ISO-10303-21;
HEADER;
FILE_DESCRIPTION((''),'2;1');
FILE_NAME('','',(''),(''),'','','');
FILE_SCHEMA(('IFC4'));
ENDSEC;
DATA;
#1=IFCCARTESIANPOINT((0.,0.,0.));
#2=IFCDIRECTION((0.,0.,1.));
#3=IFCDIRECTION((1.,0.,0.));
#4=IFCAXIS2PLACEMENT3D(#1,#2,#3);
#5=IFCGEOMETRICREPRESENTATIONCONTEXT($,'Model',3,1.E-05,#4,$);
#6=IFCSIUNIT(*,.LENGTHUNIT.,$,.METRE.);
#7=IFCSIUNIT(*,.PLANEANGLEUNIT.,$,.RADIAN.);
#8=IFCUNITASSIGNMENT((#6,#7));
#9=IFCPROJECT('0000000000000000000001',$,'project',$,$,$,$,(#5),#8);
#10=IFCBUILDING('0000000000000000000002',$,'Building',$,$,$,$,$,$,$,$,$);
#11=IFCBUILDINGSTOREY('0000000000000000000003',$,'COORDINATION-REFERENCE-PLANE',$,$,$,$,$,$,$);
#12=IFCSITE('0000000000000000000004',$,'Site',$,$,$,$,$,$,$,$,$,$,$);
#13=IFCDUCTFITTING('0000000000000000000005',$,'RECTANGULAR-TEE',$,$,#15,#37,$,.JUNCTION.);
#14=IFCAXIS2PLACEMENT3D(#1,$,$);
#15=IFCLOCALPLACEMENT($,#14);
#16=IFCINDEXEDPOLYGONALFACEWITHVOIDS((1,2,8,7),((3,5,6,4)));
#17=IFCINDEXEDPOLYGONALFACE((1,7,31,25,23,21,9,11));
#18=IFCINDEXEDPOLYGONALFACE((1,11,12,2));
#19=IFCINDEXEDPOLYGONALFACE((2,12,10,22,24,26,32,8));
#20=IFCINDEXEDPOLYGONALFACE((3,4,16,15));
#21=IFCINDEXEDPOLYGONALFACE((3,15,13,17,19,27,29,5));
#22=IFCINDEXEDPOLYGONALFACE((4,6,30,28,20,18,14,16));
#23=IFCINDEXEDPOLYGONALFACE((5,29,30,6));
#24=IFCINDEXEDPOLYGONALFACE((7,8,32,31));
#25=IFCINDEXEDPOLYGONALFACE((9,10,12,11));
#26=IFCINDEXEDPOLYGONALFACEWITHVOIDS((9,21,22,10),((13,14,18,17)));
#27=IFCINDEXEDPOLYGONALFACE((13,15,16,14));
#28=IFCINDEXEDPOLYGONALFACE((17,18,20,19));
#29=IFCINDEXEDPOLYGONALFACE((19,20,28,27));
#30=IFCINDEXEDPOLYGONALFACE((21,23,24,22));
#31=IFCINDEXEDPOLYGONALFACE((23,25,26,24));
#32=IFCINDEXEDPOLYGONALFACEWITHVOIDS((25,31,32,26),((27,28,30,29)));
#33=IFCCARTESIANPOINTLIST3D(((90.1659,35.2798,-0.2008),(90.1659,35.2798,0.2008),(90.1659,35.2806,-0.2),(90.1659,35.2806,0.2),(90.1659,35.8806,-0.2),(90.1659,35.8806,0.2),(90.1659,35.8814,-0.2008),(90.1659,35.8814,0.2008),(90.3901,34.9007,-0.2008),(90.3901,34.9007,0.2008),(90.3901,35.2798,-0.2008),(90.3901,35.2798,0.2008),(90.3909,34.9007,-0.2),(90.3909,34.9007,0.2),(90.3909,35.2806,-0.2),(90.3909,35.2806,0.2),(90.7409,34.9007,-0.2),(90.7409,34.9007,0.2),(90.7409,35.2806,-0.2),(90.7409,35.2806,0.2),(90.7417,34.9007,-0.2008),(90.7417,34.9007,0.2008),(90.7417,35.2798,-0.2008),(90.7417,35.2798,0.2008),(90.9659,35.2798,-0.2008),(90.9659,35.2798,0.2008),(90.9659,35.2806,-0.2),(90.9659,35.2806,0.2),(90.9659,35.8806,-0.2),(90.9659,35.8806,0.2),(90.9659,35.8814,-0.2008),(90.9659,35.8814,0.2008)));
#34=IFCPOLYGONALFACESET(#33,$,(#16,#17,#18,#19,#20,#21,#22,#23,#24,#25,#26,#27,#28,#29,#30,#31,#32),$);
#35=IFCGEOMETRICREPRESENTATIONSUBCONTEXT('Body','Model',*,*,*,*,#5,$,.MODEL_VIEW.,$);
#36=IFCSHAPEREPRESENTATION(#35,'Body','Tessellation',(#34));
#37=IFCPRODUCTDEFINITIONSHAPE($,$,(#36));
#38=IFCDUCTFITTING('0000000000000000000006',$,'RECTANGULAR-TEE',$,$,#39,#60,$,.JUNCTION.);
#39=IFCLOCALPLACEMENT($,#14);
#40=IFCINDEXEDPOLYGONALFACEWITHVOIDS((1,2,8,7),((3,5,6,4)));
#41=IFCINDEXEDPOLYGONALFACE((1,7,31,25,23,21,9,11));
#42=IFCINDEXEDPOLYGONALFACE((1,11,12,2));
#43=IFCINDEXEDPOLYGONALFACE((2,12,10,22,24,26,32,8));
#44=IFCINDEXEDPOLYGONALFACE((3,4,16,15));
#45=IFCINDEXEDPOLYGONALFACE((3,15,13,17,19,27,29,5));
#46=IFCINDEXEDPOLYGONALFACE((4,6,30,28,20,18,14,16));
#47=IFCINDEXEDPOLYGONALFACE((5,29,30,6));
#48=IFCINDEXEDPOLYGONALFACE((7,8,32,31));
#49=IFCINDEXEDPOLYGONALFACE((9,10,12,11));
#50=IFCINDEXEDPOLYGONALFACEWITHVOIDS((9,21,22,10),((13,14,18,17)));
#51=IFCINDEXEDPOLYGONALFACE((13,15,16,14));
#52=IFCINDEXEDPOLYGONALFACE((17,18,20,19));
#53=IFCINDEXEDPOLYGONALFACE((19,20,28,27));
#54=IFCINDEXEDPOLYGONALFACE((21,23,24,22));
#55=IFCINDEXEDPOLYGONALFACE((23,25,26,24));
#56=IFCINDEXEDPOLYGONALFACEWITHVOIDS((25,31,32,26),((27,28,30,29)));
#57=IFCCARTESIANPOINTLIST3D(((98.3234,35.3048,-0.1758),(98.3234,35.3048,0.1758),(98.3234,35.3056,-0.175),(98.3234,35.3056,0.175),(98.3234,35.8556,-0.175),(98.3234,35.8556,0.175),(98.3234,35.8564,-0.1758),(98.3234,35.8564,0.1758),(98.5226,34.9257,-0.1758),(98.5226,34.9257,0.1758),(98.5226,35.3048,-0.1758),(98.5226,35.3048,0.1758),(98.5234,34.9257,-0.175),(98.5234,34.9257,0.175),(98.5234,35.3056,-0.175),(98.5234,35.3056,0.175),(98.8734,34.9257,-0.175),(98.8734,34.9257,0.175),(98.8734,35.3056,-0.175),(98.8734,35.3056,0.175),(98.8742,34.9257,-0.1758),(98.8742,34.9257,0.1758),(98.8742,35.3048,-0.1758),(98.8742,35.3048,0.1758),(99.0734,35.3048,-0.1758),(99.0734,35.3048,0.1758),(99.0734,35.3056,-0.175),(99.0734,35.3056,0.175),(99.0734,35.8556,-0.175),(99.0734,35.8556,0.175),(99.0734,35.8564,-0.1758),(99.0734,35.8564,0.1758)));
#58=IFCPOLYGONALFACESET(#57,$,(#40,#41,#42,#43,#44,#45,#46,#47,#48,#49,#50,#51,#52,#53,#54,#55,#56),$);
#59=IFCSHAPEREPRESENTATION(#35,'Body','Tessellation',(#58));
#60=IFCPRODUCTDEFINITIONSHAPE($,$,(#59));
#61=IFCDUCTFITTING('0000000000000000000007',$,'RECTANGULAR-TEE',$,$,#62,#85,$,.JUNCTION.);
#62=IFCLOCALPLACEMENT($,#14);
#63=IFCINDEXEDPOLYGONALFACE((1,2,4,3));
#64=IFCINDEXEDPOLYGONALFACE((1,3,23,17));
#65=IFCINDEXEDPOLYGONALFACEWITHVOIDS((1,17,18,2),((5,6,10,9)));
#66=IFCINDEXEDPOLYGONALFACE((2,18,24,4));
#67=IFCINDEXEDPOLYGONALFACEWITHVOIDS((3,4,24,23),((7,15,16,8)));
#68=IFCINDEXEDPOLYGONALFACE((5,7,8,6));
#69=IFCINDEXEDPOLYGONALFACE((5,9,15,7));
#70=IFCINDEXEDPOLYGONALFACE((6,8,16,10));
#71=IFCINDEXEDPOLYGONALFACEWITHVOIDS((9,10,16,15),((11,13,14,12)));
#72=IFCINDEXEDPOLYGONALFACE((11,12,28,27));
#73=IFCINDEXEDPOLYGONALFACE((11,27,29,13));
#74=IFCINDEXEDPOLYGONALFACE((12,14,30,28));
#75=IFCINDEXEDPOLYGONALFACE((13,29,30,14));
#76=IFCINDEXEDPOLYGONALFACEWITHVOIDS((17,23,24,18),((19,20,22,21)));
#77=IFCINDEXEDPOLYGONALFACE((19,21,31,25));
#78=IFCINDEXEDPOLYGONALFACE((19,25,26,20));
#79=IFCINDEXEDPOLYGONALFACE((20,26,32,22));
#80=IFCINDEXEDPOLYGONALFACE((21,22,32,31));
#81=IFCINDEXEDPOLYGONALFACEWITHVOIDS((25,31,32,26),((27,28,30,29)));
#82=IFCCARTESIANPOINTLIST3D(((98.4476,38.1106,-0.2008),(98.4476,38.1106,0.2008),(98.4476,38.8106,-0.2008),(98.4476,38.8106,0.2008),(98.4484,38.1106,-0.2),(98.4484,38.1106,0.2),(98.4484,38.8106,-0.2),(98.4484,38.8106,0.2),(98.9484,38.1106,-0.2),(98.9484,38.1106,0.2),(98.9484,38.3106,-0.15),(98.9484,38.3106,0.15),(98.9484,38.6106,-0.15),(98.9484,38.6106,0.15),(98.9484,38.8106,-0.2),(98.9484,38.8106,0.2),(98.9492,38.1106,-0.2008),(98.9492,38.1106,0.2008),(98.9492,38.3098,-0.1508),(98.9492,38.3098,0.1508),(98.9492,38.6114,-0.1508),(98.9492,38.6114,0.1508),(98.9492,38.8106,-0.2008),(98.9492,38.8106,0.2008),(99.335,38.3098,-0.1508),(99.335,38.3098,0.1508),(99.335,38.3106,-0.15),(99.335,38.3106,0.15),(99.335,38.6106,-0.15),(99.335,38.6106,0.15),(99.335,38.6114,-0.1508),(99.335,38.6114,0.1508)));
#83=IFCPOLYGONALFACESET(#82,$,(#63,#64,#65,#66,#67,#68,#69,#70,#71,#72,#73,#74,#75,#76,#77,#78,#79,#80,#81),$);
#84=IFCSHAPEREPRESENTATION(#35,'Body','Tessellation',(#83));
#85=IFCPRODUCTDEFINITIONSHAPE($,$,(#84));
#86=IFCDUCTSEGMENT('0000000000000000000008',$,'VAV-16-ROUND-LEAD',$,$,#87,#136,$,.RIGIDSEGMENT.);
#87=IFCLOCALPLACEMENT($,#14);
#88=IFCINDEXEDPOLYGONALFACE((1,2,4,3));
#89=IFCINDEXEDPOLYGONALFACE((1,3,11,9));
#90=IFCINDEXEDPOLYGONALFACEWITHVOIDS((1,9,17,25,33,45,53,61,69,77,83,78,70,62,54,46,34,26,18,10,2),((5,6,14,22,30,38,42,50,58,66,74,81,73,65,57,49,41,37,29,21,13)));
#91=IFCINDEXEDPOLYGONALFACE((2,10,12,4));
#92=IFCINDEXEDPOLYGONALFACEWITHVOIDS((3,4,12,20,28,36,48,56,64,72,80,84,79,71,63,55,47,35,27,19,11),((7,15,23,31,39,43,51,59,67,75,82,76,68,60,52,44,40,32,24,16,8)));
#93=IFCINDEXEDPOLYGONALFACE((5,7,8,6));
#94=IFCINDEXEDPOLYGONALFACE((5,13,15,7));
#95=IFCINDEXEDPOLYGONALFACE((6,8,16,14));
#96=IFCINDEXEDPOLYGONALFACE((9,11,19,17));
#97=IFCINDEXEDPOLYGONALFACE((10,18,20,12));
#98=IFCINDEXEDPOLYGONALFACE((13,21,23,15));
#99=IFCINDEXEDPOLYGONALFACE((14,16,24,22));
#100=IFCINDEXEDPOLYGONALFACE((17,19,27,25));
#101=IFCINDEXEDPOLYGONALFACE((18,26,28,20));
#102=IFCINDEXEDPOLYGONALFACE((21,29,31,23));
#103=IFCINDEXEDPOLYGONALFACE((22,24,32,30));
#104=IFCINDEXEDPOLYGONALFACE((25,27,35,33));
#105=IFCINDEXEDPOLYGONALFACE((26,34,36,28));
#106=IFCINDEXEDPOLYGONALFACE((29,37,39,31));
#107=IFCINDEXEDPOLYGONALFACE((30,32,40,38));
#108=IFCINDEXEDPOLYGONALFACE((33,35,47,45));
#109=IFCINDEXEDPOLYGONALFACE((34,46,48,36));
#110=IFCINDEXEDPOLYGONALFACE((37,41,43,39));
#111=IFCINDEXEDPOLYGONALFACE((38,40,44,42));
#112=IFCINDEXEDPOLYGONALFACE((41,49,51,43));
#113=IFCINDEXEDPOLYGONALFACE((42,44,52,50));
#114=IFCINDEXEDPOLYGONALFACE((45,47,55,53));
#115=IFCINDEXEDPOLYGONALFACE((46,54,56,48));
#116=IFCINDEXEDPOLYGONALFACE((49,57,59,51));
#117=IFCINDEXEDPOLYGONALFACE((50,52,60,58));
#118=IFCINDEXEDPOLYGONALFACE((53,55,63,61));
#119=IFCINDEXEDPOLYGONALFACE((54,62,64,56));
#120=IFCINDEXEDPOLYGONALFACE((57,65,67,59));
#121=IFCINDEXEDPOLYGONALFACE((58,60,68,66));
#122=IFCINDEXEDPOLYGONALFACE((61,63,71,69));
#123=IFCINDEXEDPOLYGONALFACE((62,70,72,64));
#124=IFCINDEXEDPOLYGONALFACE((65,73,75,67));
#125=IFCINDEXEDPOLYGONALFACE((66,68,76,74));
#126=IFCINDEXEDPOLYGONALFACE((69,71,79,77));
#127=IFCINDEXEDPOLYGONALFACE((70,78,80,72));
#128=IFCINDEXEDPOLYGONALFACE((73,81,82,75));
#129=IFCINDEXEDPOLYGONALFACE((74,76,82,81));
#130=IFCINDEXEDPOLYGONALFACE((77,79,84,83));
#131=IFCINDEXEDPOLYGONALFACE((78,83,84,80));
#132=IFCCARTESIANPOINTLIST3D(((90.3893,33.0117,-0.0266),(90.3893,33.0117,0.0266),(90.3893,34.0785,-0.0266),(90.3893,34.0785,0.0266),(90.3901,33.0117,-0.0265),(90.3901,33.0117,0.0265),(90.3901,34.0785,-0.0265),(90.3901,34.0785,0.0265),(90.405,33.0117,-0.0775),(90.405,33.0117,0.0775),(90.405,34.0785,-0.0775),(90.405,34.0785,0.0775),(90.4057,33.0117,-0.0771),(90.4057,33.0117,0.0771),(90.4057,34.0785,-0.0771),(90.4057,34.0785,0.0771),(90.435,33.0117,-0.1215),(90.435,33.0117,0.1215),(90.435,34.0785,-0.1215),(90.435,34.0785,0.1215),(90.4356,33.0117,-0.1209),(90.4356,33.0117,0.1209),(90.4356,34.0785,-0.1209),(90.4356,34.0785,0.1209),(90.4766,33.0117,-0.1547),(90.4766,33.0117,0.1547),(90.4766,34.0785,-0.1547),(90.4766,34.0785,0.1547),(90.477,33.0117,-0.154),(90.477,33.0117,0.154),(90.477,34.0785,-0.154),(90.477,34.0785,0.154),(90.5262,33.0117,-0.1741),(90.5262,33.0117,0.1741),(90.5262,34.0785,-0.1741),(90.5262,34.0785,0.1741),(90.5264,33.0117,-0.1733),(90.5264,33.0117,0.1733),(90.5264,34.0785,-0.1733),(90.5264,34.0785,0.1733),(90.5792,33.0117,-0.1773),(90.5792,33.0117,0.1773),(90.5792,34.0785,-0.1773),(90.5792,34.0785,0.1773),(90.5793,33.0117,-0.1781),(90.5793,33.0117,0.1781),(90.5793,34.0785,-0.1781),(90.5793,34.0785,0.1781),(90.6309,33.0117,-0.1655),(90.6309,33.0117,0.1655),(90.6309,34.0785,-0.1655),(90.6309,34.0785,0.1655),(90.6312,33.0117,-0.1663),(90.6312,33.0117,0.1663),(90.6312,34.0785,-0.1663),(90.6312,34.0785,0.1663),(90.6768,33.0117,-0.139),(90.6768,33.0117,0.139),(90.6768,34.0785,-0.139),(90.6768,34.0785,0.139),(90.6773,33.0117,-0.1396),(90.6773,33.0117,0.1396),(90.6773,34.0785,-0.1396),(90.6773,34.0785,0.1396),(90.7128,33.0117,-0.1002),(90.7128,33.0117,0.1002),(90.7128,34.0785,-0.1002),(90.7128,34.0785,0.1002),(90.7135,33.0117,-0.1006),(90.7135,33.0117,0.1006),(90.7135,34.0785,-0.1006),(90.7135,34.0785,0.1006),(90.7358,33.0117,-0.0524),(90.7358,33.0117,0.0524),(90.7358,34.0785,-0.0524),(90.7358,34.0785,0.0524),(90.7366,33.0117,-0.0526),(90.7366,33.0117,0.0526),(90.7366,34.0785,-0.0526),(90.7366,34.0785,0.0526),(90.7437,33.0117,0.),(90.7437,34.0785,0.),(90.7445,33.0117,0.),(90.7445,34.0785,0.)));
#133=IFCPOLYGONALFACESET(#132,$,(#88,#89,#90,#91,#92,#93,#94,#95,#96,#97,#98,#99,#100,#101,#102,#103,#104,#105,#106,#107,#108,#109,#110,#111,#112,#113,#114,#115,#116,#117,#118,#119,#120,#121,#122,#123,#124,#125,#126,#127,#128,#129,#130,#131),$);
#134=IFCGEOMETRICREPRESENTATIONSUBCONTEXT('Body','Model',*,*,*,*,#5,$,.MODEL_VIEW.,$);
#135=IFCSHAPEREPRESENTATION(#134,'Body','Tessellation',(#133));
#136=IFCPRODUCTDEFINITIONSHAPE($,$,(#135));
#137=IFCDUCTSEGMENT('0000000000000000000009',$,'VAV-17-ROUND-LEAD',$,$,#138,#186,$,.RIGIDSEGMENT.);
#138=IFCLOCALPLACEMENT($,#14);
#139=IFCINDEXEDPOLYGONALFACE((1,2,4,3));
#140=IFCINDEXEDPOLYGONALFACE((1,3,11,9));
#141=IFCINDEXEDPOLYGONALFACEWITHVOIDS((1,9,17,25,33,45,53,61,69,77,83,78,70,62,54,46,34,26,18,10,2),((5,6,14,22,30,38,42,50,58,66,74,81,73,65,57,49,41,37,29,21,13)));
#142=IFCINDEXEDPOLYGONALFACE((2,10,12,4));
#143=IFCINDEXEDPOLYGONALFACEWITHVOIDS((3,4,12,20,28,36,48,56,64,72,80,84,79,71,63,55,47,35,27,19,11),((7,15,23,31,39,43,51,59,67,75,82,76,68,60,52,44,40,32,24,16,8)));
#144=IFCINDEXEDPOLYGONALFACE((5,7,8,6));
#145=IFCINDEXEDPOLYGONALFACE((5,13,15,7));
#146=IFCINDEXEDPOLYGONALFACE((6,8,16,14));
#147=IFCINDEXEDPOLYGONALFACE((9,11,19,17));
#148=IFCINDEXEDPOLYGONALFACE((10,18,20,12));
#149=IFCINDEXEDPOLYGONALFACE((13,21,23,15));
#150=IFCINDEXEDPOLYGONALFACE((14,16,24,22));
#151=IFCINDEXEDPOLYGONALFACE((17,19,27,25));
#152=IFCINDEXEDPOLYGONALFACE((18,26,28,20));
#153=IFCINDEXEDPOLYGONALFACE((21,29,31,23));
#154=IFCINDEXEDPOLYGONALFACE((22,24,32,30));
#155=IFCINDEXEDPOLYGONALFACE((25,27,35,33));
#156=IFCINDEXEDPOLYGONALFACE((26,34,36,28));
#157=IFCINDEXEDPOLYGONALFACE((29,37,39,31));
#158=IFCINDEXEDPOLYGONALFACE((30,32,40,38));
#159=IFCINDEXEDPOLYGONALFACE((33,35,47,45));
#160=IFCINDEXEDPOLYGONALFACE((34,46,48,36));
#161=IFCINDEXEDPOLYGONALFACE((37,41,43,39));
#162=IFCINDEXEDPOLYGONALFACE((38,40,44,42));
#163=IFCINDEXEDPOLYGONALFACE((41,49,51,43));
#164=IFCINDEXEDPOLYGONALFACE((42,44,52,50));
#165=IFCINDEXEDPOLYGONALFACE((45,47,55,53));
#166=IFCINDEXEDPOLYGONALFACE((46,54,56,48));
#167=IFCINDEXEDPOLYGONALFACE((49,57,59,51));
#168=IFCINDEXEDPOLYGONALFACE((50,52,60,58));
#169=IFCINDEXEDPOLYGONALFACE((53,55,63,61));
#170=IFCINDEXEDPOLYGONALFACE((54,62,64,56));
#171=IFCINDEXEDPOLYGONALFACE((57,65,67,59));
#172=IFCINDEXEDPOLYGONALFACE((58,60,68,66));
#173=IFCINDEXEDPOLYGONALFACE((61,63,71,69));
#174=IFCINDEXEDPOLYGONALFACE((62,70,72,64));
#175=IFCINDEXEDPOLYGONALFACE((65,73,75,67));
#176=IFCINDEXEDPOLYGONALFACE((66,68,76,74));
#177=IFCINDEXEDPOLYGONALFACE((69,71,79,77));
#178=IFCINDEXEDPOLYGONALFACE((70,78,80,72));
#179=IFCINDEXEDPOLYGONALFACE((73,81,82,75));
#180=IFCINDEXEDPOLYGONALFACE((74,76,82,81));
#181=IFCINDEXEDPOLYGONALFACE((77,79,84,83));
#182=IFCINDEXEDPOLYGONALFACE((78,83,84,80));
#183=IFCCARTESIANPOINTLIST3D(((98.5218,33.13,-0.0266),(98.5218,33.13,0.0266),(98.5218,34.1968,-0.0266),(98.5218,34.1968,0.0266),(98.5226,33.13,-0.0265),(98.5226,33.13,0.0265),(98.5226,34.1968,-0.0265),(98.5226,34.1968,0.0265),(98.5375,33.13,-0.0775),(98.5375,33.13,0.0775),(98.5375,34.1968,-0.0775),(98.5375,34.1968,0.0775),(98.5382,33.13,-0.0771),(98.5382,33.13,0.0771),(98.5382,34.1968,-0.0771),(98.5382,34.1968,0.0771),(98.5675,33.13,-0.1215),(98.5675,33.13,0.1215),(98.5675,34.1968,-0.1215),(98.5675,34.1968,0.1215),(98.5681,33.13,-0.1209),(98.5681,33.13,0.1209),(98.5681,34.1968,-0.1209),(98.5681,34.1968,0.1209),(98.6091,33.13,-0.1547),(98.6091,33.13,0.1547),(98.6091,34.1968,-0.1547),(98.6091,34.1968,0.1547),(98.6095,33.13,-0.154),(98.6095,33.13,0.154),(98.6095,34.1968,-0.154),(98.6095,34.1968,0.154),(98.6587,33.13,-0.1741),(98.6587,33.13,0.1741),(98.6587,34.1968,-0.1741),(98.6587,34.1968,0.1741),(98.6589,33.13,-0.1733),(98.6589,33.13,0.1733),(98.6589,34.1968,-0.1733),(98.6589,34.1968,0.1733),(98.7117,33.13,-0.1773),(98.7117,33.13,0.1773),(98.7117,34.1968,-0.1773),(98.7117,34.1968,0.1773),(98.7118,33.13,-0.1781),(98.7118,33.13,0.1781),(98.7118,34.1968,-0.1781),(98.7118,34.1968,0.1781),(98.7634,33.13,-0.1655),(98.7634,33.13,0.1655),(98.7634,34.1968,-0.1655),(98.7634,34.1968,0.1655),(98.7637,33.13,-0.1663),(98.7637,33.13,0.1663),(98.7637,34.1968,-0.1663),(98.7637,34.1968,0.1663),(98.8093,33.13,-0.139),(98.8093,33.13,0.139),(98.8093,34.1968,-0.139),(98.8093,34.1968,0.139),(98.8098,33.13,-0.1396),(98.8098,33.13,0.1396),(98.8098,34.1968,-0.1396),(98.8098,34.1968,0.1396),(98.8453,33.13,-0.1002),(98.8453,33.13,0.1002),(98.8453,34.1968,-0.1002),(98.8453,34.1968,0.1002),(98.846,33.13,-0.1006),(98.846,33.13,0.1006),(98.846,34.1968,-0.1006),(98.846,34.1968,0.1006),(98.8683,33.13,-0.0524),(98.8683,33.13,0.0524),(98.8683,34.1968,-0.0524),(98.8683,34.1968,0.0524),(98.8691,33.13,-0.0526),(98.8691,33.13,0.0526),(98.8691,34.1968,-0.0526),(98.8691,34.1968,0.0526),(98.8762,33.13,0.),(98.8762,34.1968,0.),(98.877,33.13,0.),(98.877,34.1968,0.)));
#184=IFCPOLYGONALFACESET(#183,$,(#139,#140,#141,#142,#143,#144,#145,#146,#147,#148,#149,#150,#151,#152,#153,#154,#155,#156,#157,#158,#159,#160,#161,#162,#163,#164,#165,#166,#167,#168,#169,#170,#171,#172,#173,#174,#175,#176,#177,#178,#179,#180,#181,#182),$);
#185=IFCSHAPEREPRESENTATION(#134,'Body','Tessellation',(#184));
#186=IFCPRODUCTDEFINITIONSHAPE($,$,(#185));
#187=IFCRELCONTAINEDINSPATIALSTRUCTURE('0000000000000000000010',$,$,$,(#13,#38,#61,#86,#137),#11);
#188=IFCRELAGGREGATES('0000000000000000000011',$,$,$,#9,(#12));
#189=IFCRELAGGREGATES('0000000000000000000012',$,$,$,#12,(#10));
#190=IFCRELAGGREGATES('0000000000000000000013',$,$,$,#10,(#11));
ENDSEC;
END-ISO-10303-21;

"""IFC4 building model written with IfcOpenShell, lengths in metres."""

from ifc_helpers import new_model, si_unit, frame, origin, origin_with_axes, place, context, subcontext, project, spatial, rectangle, hollow_circle, extrude, boolean, element, save


model = new_model("IFC4")

# Units and contexts
model_context = context("Model", 3, precision=1e-05, world=origin_with_axes())
body_context_1 = subcontext(model_context, "Body", "Model", "MODEL_VIEW")
body_context_2 = subcontext(model_context, "Body", "Model", "MODEL_VIEW")
ifc_project = project(units=[si_unit("LENGTHUNIT", "METRE"), si_unit("PLANEANGLEUNIT", "RADIAN")], contexts=[model_context])

# Site, building, storey
site = spatial("IfcSite", under=ifc_project, Name="Site")
building = spatial("IfcBuilding", under=site, Name="Building")
storey = spatial("IfcBuildingStorey", under=building, Name="COORDINATION-REFERENCE-PLANE")

# Duct fittings
duct_fitting_1_placement = place(None, frame((90.5659, 35.5806, 0.0), z_axis=(1.0, 0.0, 0.0), x_axis=(0.0, -1.0, 0.0)))
solid_1 = boolean("UNION", extrude(rectangle(XDim=0.6, YDim=0.4), frame((0.0, 0.0, -0.4), z_axis=(0.0, 0.0, 1.0), x_axis=(1.0, 0.0, 0.0)), (0.0, 0.0, 1.0), 0.8), extrude(rectangle(XDim=0.35, YDim=0.4), frame((0.0, 0.0, 0.0), z_axis=(1.0, 0.0, 0.0), x_axis=(0.0, 0.0, -1.0)), (0.0, 0.0, 1.0), 0.6799))
element("IfcDuctFitting", 1, at=duct_fitting_1_placement, inside=storey, Name="RECTANGULAR-TEE", PredefinedType="JUNCTION", context=body_context_1, shape_type="CSG", body=[
    boolean("DIFFERENCE", boolean("UNION", extrude(rectangle(XDim=0.6016, YDim=0.4016), frame((0.0, 0.0, -0.4), z_axis=(0.0, 0.0, 1.0), x_axis=(1.0, 0.0, 0.0)), (0.0, 0.0, 1.0), 0.8), extrude(rectangle(XDim=0.3516, YDim=0.4016), frame((0.0, 0.0, 0.0), z_axis=(1.0, 0.0, 0.0), x_axis=(0.0, 0.0, -1.0)), (0.0, 0.0, 1.0), 0.6799)), solid_1),
])
duct_fitting_2_placement = place(None, frame((98.6984, 35.5806, 0.0), z_axis=(1.0, 0.0, 0.0), x_axis=(0.0, -1.0, 0.0)))
solid_2 = boolean("UNION", extrude(rectangle(XDim=0.55, YDim=0.35), frame((0.0, 0.0, -0.375), z_axis=(0.0, 0.0, 1.0), x_axis=(1.0, 0.0, 0.0)), (0.0, 0.0, 1.0), 0.75), extrude(rectangle(XDim=0.35, YDim=0.35), frame((0.0, 0.0, 0.0), z_axis=(1.0, 0.0, 0.0), x_axis=(0.0, 0.0, -1.0)), (0.0, 0.0, 1.0), 0.6549))
element("IfcDuctFitting", 2, at=duct_fitting_2_placement, inside=storey, Name="RECTANGULAR-TEE", PredefinedType="JUNCTION", context=body_context_1, shape_type="CSG", body=[
    boolean("DIFFERENCE", boolean("UNION", extrude(rectangle(XDim=0.5516, YDim=0.3516), frame((0.0, 0.0, -0.375), z_axis=(0.0, 0.0, 1.0), x_axis=(1.0, 0.0, 0.0)), (0.0, 0.0, 1.0), 0.75), extrude(rectangle(XDim=0.3516, YDim=0.3516), frame((0.0, 0.0, 0.0), z_axis=(1.0, 0.0, 0.0), x_axis=(0.0, 0.0, -1.0)), (0.0, 0.0, 1.0), 0.6549)), solid_2),
])
duct_fitting_3_placement = place(None, frame((98.6984, 38.4606, 0.0), z_axis=(0.0, 1.0, 0.0), x_axis=(1.0, 0.0, 0.0)))
solid_3 = boolean("UNION", extrude(rectangle(XDim=0.5, YDim=0.4), frame((0.0, 0.0, -0.35), z_axis=(0.0, 0.0, 1.0), x_axis=(1.0, 0.0, 0.0)), (0.0, 0.0, 1.0), 0.7), extrude(rectangle(XDim=0.3, YDim=0.3), frame((0.0, 0.0, 0.0), z_axis=(1.0, 0.0, 0.0), x_axis=(0.0, 0.0, -1.0)), (0.0, 0.0, 1.0), 0.6366))
element("IfcDuctFitting", 3, at=duct_fitting_3_placement, inside=storey, Name="RECTANGULAR-TEE", PredefinedType="JUNCTION", context=body_context_1, shape_type="CSG", body=[
    boolean("DIFFERENCE", boolean("UNION", extrude(rectangle(XDim=0.5016, YDim=0.4016), frame((0.0, 0.0, -0.35), z_axis=(0.0, 0.0, 1.0), x_axis=(1.0, 0.0, 0.0)), (0.0, 0.0, 1.0), 0.7), extrude(rectangle(XDim=0.3016, YDim=0.3016), frame((0.0, 0.0, 0.0), z_axis=(1.0, 0.0, 0.0), x_axis=(0.0, 0.0, -1.0)), (0.0, 0.0, 1.0), 0.6366)), solid_3),
])

# Duct segments
for number, where, z_axis, x_axis, name in (
    (4, (90.5659, 34.0785, 0.0), (0.0, -1.0, 0.0), (1.0, 0.0, 0.0), "VAV-16-ROUND-LEAD"),
    (5, (98.6984, 34.1968, 0.0), (0.0, -1.0, 0.0), (1.0, 0.0, 0.0), "VAV-17-ROUND-LEAD"),
):
    element("IfcDuctSegment", number, at=place(None, frame(where, z_axis=z_axis, x_axis=x_axis)), inside=storey, Name=name, PredefinedType="RIGIDSEGMENT", context=body_context_2, shape_type="SweptSolid", body=[
        extrude(hollow_circle(Radius=0.1786, WallThickness=0.0008), origin(), (0.0, 0.0, 1.0), 1.0668),
    ])

save(model, "model.ifc")
